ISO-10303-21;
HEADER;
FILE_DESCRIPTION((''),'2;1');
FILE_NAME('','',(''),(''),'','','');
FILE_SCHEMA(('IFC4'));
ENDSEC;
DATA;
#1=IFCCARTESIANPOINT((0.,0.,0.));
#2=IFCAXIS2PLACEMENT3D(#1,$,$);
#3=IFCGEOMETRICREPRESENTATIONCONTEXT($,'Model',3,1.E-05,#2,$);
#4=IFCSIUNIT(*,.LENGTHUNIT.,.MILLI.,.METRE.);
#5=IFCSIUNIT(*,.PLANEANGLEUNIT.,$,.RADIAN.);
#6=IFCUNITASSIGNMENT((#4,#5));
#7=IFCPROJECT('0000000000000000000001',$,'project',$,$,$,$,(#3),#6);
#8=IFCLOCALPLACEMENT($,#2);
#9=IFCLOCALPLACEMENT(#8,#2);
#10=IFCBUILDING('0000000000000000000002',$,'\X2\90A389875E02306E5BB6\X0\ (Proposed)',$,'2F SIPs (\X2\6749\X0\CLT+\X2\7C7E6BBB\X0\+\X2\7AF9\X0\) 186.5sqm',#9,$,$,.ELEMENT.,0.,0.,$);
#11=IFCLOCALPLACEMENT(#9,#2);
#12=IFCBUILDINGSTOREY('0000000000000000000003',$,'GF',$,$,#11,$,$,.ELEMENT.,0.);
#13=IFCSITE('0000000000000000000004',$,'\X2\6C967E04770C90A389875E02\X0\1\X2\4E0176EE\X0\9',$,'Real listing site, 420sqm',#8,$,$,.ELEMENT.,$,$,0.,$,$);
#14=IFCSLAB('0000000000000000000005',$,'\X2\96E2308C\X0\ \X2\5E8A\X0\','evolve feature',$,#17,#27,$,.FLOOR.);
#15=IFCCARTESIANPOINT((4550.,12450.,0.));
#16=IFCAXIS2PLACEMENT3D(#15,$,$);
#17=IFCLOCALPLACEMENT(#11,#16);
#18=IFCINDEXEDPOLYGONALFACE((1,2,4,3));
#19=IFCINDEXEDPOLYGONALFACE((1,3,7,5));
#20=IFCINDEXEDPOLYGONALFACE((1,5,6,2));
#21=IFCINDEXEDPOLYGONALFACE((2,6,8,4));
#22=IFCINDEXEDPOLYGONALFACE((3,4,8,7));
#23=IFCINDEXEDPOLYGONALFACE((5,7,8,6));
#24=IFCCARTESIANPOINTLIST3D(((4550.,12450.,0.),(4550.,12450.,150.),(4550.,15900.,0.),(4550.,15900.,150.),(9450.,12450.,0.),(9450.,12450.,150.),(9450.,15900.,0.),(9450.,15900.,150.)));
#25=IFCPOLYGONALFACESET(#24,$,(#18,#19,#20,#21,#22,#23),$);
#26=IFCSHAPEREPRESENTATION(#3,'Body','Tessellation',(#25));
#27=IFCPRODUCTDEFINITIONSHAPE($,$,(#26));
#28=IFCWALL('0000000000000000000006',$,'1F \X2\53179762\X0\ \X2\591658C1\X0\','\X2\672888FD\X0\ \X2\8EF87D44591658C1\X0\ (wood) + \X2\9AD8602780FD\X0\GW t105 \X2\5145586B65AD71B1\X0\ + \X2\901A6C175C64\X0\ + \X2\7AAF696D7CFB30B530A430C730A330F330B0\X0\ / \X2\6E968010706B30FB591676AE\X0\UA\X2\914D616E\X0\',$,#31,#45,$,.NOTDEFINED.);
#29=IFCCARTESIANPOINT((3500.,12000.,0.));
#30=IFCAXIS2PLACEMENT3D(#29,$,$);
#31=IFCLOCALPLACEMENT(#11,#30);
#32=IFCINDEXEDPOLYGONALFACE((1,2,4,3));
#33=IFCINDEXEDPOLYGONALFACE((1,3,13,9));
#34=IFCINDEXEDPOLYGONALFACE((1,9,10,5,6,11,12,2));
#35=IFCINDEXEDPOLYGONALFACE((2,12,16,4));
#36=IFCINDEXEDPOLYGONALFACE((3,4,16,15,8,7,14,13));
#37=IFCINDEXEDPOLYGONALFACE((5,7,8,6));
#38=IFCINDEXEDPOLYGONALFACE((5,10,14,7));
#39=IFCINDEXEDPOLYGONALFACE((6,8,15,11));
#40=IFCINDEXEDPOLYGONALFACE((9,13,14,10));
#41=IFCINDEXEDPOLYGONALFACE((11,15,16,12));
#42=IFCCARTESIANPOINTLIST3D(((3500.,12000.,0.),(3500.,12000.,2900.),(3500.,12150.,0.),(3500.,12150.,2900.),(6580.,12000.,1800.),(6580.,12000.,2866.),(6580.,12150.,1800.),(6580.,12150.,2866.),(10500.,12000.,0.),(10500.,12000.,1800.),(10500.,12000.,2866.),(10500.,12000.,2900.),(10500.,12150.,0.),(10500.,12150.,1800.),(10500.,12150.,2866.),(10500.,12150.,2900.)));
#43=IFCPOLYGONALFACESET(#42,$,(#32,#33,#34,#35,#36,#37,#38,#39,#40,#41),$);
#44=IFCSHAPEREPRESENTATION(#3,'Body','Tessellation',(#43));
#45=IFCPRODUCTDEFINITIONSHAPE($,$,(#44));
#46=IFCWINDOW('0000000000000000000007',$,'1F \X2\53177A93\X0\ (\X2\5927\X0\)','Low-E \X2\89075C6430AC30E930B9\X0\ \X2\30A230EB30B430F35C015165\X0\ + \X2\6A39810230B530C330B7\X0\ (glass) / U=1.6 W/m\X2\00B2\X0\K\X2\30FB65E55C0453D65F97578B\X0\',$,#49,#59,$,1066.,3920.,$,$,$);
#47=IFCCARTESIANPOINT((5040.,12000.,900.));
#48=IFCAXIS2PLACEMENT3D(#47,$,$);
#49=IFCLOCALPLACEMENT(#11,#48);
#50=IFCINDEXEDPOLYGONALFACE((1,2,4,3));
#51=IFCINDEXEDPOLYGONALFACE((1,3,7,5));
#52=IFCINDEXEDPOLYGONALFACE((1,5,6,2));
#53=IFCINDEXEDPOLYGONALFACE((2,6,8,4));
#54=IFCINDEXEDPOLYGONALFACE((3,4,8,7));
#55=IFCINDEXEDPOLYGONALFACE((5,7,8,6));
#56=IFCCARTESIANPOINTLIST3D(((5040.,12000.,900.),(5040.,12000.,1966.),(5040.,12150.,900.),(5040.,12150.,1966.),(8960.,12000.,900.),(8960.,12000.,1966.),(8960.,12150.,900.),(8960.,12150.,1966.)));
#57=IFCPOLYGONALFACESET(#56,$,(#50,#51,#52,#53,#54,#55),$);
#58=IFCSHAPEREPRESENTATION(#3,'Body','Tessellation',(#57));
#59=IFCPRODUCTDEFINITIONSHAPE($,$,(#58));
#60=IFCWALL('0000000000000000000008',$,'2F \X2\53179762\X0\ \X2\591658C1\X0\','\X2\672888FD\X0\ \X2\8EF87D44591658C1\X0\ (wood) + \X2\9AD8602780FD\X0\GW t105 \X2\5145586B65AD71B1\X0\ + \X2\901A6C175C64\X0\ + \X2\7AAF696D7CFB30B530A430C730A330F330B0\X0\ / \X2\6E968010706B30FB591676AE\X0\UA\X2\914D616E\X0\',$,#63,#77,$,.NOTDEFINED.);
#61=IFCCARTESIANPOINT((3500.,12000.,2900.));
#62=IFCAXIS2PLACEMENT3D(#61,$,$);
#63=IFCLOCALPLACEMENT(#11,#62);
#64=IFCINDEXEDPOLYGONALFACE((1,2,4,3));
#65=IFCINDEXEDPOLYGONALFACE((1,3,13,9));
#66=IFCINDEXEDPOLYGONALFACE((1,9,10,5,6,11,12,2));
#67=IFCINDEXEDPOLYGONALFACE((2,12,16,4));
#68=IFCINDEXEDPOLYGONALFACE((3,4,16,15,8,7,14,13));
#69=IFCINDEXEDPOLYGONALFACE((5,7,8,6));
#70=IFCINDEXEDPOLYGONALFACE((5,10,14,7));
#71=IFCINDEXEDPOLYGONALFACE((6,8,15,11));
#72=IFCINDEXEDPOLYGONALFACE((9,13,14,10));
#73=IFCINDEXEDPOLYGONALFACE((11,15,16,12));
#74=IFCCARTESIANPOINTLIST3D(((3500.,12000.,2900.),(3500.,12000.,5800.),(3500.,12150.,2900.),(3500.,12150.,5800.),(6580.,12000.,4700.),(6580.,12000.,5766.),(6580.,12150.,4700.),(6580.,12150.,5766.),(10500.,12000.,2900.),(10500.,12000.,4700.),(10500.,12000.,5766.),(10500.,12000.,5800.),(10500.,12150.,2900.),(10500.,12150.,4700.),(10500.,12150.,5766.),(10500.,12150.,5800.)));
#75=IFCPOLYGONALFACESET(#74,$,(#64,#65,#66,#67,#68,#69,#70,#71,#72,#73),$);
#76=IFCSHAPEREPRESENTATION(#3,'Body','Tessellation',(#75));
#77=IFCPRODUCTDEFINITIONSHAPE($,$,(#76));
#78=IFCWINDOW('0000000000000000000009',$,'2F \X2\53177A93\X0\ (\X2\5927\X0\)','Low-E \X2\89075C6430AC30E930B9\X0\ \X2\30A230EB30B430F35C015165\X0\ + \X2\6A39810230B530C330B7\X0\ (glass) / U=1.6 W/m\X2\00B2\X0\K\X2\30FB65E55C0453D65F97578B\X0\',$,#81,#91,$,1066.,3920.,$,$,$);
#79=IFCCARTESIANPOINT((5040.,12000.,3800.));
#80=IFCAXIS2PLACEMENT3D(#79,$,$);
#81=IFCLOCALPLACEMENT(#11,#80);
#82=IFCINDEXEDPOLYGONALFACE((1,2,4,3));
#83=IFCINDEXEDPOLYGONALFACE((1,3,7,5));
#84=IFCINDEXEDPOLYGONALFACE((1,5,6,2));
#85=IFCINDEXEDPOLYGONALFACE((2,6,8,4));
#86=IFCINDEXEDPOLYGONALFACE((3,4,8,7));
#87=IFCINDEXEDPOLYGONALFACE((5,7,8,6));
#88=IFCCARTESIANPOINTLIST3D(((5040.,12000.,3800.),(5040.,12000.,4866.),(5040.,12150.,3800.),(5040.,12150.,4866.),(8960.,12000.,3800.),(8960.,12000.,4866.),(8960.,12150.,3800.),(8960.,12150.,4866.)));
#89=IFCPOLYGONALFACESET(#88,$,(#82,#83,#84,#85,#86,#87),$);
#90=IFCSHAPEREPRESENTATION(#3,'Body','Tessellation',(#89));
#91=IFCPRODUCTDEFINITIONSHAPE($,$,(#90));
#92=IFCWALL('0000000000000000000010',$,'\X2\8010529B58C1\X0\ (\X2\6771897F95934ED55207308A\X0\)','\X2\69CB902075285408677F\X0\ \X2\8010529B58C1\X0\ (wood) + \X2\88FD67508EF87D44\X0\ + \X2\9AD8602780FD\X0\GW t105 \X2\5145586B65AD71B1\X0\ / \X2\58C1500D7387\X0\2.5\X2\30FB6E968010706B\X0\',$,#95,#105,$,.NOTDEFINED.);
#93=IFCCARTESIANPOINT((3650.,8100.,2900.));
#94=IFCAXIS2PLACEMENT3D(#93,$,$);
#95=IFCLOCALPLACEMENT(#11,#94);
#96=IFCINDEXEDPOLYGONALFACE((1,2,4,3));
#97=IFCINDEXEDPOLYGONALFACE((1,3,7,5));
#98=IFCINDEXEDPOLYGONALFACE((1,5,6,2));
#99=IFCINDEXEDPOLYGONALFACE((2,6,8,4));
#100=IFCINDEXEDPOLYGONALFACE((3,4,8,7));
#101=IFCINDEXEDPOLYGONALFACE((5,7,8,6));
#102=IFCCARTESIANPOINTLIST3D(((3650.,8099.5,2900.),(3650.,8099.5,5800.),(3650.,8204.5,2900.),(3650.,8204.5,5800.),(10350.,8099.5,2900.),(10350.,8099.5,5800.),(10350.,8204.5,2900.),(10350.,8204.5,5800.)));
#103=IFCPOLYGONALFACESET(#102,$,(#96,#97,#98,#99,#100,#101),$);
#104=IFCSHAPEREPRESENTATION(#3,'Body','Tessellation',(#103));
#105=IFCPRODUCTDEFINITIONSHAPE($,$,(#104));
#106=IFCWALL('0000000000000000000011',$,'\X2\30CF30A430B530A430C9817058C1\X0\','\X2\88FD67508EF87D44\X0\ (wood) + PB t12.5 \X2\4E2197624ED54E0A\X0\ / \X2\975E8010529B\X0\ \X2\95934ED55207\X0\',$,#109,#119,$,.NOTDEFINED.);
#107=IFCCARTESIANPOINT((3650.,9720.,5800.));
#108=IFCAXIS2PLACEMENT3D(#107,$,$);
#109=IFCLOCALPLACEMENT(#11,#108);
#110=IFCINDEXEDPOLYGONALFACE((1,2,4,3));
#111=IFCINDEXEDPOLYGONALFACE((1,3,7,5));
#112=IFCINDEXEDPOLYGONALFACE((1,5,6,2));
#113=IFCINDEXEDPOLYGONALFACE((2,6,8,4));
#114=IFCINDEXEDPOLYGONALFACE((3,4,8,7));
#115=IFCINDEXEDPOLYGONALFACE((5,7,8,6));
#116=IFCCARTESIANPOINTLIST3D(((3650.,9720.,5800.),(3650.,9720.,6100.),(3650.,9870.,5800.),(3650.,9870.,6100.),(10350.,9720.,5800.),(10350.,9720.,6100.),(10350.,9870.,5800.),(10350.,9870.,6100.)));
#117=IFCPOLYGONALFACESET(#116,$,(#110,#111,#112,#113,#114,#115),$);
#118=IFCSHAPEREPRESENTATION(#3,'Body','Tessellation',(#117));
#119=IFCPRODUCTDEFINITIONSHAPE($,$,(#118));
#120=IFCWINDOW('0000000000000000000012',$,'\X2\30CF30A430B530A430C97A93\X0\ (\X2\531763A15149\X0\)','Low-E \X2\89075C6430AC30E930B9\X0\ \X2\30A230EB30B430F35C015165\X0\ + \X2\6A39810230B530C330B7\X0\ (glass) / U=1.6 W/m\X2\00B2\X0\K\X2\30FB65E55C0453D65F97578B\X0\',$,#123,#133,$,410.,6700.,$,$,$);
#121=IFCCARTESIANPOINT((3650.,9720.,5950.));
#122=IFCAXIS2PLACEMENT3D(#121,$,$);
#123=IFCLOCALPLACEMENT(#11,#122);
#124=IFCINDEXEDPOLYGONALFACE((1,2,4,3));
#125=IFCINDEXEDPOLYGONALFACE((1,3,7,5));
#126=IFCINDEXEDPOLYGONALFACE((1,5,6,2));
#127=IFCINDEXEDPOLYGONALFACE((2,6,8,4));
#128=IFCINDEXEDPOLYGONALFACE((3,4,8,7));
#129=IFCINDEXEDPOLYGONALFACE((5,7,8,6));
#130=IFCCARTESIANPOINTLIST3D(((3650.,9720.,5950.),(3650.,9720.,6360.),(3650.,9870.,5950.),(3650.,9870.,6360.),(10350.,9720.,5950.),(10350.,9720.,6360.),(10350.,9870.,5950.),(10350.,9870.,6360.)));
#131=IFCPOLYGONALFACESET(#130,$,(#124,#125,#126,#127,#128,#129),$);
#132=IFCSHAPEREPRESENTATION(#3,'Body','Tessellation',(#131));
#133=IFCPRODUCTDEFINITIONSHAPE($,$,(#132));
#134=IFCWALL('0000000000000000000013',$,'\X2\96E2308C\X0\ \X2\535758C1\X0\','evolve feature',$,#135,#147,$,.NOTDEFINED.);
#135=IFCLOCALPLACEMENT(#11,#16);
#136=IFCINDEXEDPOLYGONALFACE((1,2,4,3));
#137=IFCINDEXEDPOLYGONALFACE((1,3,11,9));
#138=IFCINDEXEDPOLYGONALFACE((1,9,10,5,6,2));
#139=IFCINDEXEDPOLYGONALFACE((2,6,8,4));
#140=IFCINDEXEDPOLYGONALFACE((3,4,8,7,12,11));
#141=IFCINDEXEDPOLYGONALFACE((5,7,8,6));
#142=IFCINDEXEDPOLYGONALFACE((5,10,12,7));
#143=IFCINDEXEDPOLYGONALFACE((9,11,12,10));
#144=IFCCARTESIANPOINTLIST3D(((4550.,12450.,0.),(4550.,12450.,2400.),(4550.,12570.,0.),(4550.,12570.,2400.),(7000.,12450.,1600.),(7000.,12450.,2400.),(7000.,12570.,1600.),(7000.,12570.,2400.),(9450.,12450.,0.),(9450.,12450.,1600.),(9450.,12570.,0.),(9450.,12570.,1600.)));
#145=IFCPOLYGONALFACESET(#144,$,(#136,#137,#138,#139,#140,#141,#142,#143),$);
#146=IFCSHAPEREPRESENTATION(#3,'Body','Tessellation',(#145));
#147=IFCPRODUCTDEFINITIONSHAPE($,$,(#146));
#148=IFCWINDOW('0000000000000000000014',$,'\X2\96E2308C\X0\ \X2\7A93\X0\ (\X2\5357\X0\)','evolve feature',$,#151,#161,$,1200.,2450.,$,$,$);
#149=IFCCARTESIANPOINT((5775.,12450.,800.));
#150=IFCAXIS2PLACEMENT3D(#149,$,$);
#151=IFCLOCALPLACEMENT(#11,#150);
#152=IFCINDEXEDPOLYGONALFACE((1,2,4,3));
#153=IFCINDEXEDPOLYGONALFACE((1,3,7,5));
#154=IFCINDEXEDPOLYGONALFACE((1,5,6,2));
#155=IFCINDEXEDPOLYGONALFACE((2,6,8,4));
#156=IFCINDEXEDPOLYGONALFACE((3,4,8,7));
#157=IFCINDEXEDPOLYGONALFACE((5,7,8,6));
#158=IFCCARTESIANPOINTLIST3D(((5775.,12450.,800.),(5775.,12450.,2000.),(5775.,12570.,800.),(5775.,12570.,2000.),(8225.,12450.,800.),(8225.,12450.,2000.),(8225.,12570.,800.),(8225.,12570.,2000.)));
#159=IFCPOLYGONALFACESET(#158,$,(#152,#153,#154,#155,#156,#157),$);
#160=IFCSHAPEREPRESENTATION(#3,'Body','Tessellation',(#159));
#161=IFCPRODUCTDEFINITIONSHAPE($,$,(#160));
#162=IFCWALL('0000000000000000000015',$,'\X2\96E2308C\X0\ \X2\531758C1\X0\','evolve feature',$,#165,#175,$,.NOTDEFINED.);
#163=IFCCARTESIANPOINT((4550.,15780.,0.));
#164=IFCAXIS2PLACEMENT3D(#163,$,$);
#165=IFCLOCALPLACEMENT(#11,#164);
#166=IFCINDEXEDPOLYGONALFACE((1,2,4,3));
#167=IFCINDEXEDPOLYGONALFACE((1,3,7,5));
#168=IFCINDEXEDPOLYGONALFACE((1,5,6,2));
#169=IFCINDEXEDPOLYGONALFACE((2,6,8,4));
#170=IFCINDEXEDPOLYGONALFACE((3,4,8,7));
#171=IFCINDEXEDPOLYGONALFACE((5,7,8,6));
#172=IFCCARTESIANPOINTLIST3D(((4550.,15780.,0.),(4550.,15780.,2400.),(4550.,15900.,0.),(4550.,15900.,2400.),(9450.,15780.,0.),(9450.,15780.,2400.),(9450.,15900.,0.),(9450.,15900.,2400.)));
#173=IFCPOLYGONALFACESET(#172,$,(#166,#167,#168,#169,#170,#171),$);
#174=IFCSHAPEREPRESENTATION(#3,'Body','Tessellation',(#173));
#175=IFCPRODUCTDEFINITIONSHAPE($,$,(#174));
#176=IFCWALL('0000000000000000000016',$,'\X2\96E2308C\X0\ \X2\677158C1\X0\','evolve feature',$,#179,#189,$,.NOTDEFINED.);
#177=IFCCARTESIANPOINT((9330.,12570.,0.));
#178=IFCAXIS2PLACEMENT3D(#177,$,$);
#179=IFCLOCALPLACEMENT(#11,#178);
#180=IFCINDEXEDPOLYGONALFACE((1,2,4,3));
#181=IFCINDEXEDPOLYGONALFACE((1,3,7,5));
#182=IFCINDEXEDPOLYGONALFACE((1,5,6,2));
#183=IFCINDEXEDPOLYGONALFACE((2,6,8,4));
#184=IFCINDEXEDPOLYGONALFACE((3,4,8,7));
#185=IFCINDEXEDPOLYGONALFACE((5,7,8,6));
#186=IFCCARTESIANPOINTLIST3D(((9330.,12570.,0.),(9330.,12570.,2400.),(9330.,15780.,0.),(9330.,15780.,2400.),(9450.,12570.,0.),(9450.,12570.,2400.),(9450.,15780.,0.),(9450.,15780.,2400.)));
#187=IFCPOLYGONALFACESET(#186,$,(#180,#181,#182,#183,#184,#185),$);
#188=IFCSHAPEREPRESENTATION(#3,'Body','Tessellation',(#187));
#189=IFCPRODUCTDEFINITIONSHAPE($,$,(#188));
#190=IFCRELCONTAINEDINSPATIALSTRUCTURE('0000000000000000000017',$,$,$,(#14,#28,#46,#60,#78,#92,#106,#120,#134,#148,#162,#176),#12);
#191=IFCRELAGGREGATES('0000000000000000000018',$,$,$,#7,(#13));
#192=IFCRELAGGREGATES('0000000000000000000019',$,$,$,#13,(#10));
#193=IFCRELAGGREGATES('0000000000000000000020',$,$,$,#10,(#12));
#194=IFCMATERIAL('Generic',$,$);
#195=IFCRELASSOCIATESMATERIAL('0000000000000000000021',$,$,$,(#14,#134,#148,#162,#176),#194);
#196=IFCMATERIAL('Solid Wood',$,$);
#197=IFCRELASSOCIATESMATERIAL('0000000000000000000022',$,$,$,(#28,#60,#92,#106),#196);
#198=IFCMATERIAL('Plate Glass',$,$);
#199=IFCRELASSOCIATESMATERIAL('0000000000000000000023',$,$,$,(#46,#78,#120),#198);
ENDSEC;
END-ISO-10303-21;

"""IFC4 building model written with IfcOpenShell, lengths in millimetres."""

from ifc_helpers import new_model, si_unit, frame, frame_2d, origin, place, context, project, spatial, rectangle, extrude, material, element, fill, save


model = new_model("IFC4")

# Units and contexts
model_context = context("Model", 3, precision=1e-05, world=origin())
ifc_project = project(units=[si_unit("LENGTHUNIT", "METRE", prefix="MILLI"), si_unit("PLANEANGLEUNIT", "RADIAN")], contexts=[model_context])

# Site, building, storey
site_placement = place(None, origin())
site = spatial("IfcSite", under=ifc_project, at=site_placement, Name="沖縄県那覇市1丁目9", ObjectType="Real listing site, 420sqm", CompositionType="ELEMENT", RefElevation=0.0)
building_placement = place(site_placement, origin())
building = spatial("IfcBuilding", under=site, at=building_placement, Name="那覇市の家 (Proposed)", ObjectType="2F SIPs (杉CLT+籾殻+竹) 186.5sqm", CompositionType="ELEMENT", ElevationOfRefHeight=0.0, ElevationOfTerrain=0.0)
storey_placement = place(building_placement, origin())
storey = spatial("IfcBuildingStorey", under=building, at=storey_placement, Name="GF", CompositionType="ELEMENT", Elevation=0.0)

# Slab
ifc_material_1 = material(Name="Generic")
slab_placement = place(storey_placement, frame((4550.0, 12450.0, 0.0)))
element("IfcSlab", 1, at=slab_placement, inside=storey, material=ifc_material_1, Name="離れ 床", Description="evolve feature", PredefinedType="FLOOR", context=model_context, shape_type="SweptSolid", body=[
    extrude(rectangle(XDim=4900.0, YDim=3450.0, at=frame_2d((2450.0, 1725.0))), frame((4550.0, 12450.0, 0.0)), (0.0, 0.0, 1.0), 150.0),
])

# Wall, opening, window
ifc_material_2 = material(Name="Solid Wood")
wall_1_placement = place(storey_placement, frame((3500.0, 12000.0, 0.0)))
wall_1 = element("IfcWall", 2, at=wall_1_placement, inside=storey, material=ifc_material_2, Name="1F 北面 外壁", Description="木製 軸組外壁 (wood) + 高性能GW t105 充填断熱 + 通気層 + 窯業系サイディング / 準耐火・外皮UA配慮", PredefinedType="NOTDEFINED", context=model_context, shape_type="SweptSolid", body=[
    extrude(rectangle(XDim=7000.0, YDim=150.0, at=frame_2d((3500.0, 75.0))), frame((3500.0, 12000.0, 0.0)), (0.0, 0.0, 1.0), 2900.0),
])
opening_1_placement = place(storey_placement, frame((5040.0, 12000.0, 900.0)))
opening_1 = element("IfcOpeningElement", 3, at=opening_1_placement, cuts=wall_1, PredefinedType="NOTDEFINED", context=model_context, shape_type="SweptSolid", body=[
    extrude(rectangle(XDim=3920.0, YDim=150.0, at=frame_2d((1960.0, 75.0))), frame((5040.0, 12000.0, 900.0)), (0.0, 0.0, 1.0), 1066.0),
])
ifc_material_3 = material(Name="Plate Glass")
window_1_placement = place(storey_placement, frame((5040.0, 12000.0, 900.0)))
window_1 = element("IfcWindow", 4, at=window_1_placement, inside=storey, material=ifc_material_3, Name="1F 北窓 (大)", Description="Low-E 複層ガラス アルゴン封入 + 樹脂サッシ (glass) / U=1.6 W/m²K・日射取得型", OverallHeight=1066.0, OverallWidth=3920.0, context=model_context, shape_type="SweptSolid", body=[
    extrude(rectangle(XDim=3920.0, YDim=150.0, at=frame_2d((1960.0, 75.0))), frame((5040.0, 12000.0, 900.0)), (0.0, 0.0, 1.0), 1066.0),
])
fill(opening_1, window_1)

# Wall, opening, window
wall_2_placement = place(storey_placement, frame((3500.0, 12000.0, 2900.0)))
wall_2 = element("IfcWall", 5, at=wall_2_placement, inside=storey, material=ifc_material_2, Name="2F 北面 外壁", Description="木製 軸組外壁 (wood) + 高性能GW t105 充填断熱 + 通気層 + 窯業系サイディング / 準耐火・外皮UA配慮", PredefinedType="NOTDEFINED", context=model_context, shape_type="SweptSolid", body=[
    extrude(rectangle(XDim=7000.0, YDim=150.0, at=frame_2d((3500.0, 75.0))), frame((3500.0, 12000.0, 2900.0)), (0.0, 0.0, 1.0), 2900.0),
])
opening_2_placement = place(storey_placement, frame((5040.0, 12000.0, 3800.0)))
opening_2 = element("IfcOpeningElement", 6, at=opening_2_placement, cuts=wall_2, PredefinedType="NOTDEFINED", context=model_context, shape_type="SweptSolid", body=[
    extrude(rectangle(XDim=3920.0, YDim=150.0, at=frame_2d((1960.0, 75.0))), frame((5040.0, 12000.0, 3800.0)), (0.0, 0.0, 1.0), 1066.0),
])
window_2_placement = place(storey_placement, frame((5040.0, 12000.0, 3800.0)))
window_2 = element("IfcWindow", 7, at=window_2_placement, inside=storey, material=ifc_material_3, Name="2F 北窓 (大)", Description="Low-E 複層ガラス アルゴン封入 + 樹脂サッシ (glass) / U=1.6 W/m²K・日射取得型", OverallHeight=1066.0, OverallWidth=3920.0, context=model_context, shape_type="SweptSolid", body=[
    extrude(rectangle(XDim=3920.0, YDim=150.0, at=frame_2d((1960.0, 75.0))), frame((5040.0, 12000.0, 3800.0)), (0.0, 0.0, 1.0), 1066.0),
])
fill(opening_2, window_2)

# Wall
wall_3_placement = place(storey_placement, frame((3650.0, 8100.0, 2900.0)))
element("IfcWall", 8, at=wall_3_placement, inside=storey, material=ifc_material_2, Name="耐力壁 (東西間仕切り)", Description="構造用合板 耐力壁 (wood) + 製材軸組 + 高性能GW t105 充填断熱 / 壁倍率2.5・準耐火", PredefinedType="NOTDEFINED", context=model_context, shape_type="SweptSolid", body=[
    extrude(rectangle(XDim=6700.0, YDim=105.0, at=frame_2d((3350.0, 52.0))), frame((3650.0, 8100.0, 2900.0)), (0.0, 0.0, 1.0), 2900.0),
])

# Walls, openings, windows
wall_4_placement = place(storey_placement, frame((3650.0, 9720.0, 5800.0)))
wall_4 = element("IfcWall", 9, at=wall_4_placement, inside=storey, material=ifc_material_2, Name="ハイサイド腰壁", Description="製材軸組 (wood) + PB t12.5 両面仕上 / 非耐力 間仕切", PredefinedType="NOTDEFINED", context=model_context, shape_type="SweptSolid", body=[
    extrude(rectangle(XDim=6700.0, YDim=150.0, at=frame_2d((3350.0, 75.0))), frame((3650.0, 9720.0, 5800.0)), (0.0, 0.0, 1.0), 700.0),
])
opening_3_placement = place(storey_placement, frame((3650.0, 9720.0, 5950.0)))
opening_3 = element("IfcOpeningElement", 10, at=opening_3_placement, cuts=wall_4, PredefinedType="NOTDEFINED", context=model_context, shape_type="SweptSolid", body=[
    extrude(rectangle(XDim=6700.0, YDim=150.0, at=frame_2d((3350.0, 75.0))), frame((3650.0, 9720.0, 5950.0)), (0.0, 0.0, 1.0), 410.0),
])
window_3_placement = place(storey_placement, frame((3650.0, 9720.0, 5950.0)))
window_3 = element("IfcWindow", 11, at=window_3_placement, inside=storey, material=ifc_material_3, Name="ハイサイド窓 (北採光)", Description="Low-E 複層ガラス アルゴン封入 + 樹脂サッシ (glass) / U=1.6 W/m²K・日射取得型", OverallHeight=410.0, OverallWidth=6700.0, context=model_context, shape_type="SweptSolid", body=[
    extrude(rectangle(XDim=6700.0, YDim=150.0, at=frame_2d((3350.0, 75.0))), frame((3650.0, 9720.0, 5950.0)), (0.0, 0.0, 1.0), 410.0),
])
fill(opening_3, window_3)
wall_5_placement = place(storey_placement, frame((4550.0, 12450.0, 0.0)))
wall_5 = element("IfcWall", 12, at=wall_5_placement, inside=storey, material=ifc_material_1, Name="離れ 南壁", Description="evolve feature", PredefinedType="NOTDEFINED", context=model_context, shape_type="SweptSolid", body=[
    extrude(rectangle(XDim=4900.0, YDim=120.0, at=frame_2d((2450.0, 60.0))), frame((4550.0, 12450.0, 0.0)), (0.0, 0.0, 1.0), 2400.0),
])
opening_4_placement = place(storey_placement, frame((5775.0, 12450.0, 800.0)))
opening_4 = element("IfcOpeningElement", 13, at=opening_4_placement, cuts=wall_5, PredefinedType="NOTDEFINED", context=model_context, shape_type="SweptSolid", body=[
    extrude(rectangle(XDim=2450.0, YDim=120.0, at=frame_2d((1225.0, 60.0))), frame((5775.0, 12450.0, 800.0)), (0.0, 0.0, 1.0), 1200.0),
])
window_4_placement = place(storey_placement, frame((5775.0, 12450.0, 800.0)))
window_4 = element("IfcWindow", 14, at=window_4_placement, inside=storey, material=ifc_material_1, Name="離れ 窓 (南)", Description="evolve feature", OverallHeight=1200.0, OverallWidth=2450.0, context=model_context, shape_type="SweptSolid", body=[
    extrude(rectangle(XDim=2450.0, YDim=120.0, at=frame_2d((1225.0, 60.0))), frame((5775.0, 12450.0, 800.0)), (0.0, 0.0, 1.0), 1200.0),
])
fill(opening_4, window_4)

# Walls
wall_6_placement = place(storey_placement, frame((4550.0, 15780.0, 0.0)))
element("IfcWall", 15, at=wall_6_placement, inside=storey, material=ifc_material_1, Name="離れ 北壁", Description="evolve feature", PredefinedType="NOTDEFINED", context=model_context, shape_type="SweptSolid", body=[
    extrude(rectangle(XDim=4900.0, YDim=120.0, at=frame_2d((2450.0, 60.0))), frame((4550.0, 15780.0, 0.0)), (0.0, 0.0, 1.0), 2400.0),
])
wall_7_placement = place(storey_placement, frame((9330.0, 12570.0, 0.0)))
element("IfcWall", 16, at=wall_7_placement, inside=storey, material=ifc_material_1, Name="離れ 東壁", Description="evolve feature", PredefinedType="NOTDEFINED", context=model_context, shape_type="SweptSolid", body=[
    extrude(rectangle(XDim=120.0, YDim=3210.0, at=frame_2d((60.0, 1605.0))), frame((9330.0, 12570.0, 0.0)), (0.0, 0.0, 1.0), 2400.0),
])

save(model, "model.ifc")
